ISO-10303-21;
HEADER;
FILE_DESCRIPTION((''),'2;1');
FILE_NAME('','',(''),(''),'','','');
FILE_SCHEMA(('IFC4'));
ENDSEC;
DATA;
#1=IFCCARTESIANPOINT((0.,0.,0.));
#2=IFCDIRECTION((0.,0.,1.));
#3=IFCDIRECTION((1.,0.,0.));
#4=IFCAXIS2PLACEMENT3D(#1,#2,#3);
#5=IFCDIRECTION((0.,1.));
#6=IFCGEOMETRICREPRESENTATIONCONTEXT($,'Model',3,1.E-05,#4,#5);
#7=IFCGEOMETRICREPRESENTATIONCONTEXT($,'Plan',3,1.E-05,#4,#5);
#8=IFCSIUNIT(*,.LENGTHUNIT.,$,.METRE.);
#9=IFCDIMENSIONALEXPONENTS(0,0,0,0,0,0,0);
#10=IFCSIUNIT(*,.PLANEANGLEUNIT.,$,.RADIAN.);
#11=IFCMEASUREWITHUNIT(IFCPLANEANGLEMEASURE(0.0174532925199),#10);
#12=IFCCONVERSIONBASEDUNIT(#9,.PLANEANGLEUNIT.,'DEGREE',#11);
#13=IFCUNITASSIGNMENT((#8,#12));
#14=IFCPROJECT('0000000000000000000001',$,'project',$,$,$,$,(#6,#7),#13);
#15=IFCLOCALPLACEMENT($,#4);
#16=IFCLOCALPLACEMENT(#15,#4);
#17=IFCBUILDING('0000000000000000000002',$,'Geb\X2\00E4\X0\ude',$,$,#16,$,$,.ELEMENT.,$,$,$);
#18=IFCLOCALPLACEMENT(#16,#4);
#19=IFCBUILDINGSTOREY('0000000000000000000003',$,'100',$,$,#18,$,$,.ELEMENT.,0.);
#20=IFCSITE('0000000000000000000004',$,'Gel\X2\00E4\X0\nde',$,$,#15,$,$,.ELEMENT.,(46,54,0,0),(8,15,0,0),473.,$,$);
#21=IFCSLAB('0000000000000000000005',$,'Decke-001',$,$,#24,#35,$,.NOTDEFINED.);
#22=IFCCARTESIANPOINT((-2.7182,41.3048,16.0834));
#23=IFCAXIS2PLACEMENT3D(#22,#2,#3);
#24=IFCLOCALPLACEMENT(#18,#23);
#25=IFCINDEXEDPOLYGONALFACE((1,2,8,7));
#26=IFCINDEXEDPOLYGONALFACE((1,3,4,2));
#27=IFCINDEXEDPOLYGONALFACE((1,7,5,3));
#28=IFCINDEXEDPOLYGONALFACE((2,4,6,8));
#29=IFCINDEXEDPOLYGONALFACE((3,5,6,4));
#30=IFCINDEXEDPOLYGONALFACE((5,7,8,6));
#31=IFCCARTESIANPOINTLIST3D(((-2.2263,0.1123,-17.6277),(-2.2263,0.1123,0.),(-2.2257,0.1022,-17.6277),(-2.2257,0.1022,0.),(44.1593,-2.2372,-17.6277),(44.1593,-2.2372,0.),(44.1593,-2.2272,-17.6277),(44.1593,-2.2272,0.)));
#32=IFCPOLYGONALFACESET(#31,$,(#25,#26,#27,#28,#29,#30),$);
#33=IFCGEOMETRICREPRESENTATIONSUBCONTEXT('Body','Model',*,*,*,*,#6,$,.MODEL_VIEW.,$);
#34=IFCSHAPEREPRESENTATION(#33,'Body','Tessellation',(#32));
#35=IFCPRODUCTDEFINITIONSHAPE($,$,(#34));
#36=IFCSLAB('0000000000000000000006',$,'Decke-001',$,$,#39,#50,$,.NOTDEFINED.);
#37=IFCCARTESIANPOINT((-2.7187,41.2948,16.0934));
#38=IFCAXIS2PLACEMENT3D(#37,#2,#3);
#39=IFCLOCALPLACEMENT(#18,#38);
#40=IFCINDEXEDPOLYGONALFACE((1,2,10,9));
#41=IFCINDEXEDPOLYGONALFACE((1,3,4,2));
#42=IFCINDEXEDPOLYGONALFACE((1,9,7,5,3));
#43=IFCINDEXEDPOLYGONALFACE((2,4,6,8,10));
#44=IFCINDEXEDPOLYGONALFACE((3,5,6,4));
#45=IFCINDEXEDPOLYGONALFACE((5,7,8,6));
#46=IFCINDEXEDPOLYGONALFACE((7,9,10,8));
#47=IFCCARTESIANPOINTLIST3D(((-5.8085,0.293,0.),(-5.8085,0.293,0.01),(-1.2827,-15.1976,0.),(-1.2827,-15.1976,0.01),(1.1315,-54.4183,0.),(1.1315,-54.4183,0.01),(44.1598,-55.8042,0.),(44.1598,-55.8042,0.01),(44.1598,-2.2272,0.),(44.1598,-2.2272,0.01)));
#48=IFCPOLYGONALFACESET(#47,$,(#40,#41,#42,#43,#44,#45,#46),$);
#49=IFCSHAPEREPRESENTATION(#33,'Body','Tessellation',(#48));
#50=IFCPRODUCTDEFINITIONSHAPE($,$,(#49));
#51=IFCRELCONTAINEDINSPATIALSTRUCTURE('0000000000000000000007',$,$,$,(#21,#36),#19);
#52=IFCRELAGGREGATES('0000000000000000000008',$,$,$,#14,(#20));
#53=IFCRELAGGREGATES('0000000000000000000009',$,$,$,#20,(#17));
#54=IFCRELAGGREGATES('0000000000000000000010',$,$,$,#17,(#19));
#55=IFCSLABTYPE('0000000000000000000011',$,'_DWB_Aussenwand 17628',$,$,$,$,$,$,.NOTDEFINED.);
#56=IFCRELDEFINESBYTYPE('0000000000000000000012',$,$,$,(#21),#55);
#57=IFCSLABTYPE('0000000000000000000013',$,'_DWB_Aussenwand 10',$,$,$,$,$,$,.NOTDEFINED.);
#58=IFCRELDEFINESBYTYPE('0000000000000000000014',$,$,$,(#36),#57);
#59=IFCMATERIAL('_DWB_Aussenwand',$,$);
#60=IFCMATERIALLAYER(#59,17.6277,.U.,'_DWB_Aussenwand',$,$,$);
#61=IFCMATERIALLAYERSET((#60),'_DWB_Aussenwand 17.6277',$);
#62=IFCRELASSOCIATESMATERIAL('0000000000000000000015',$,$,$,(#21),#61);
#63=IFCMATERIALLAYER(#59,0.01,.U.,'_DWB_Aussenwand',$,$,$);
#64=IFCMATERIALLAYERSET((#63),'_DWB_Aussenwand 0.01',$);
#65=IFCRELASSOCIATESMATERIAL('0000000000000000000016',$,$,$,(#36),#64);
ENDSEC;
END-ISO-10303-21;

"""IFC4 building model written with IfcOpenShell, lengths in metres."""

from ifc_helpers import new_model, entity, si_unit, converted_unit, direction, frame, origin_with_axes, place, context, subcontext, project, spatial, line, indexed_curve, outline, extrude, material, layer, layer_set, layer_usage, type_object, element, save


model = new_model("IFC4")

# Units and contexts
model_context = context("Model", 3, precision=1e-05, world=origin_with_axes(), true_north=direction((0.0, 1.0)))
plan_context = context("Plan", 3, precision=1e-05, world=origin_with_axes(), true_north=direction((0.0, 1.0)))
body_context = subcontext(model_context, "Body", "Model", "MODEL_VIEW")
ifc_project = project(units=[si_unit("LENGTHUNIT", "METRE"), converted_unit("PLANEANGLEUNIT", "DEGREE", entity("IfcPlaneAngleMeasure", 0.0174532925199), si_unit("PLANEANGLEUNIT", "RADIAN"), dimensions=[0, 0, 0, 0, 0, 0, 0])], contexts=[model_context, plan_context])

# Site, building, storey
site_placement = place(None, origin_with_axes())
site = spatial("IfcSite", under=ifc_project, at=site_placement, Name="Gelände", CompositionType="ELEMENT", RefLatitude=(46, 54, 0, 0), RefLongitude=(8, 15, 0, 0), RefElevation=473.0)
building_placement = place(site_placement, origin_with_axes())
building = spatial("IfcBuilding", under=site, at=building_placement, Name="Gebäude", CompositionType="ELEMENT")
storey_placement = place(building_placement, origin_with_axes())
storey = spatial("IfcBuildingStorey", under=building, at=storey_placement, Name="100", CompositionType="ELEMENT", Elevation=0.0)

# Slabs
ifc_material = material(Name="_DWB_Aussenwand")
ifc_layer_1 = layer(ifc_material, 17.6277, ventilated="UNKNOWN", Name="_DWB_Aussenwand")
ifc_layer_set_1 = layer_set([ifc_layer_1], Name="_DWB_Aussenwand 17.6277")
slab_type_1 = type_object("IfcSlabType", Name="_DWB_Aussenwand 17628", PredefinedType="NOTDEFINED")
ifc_layer_usage_1 = layer_usage(ifc_layer_set_1, "AXIS3", "NEGATIVE", 17.6277)
slab_1_placement = place(storey_placement, frame((-2.7182, 41.3048, 16.0834), z_axis=(0.0, 0.0, 1.0), x_axis=(1.0, 0.0, 0.0)))
element("IfcSlab", 1, at=slab_1_placement, inside=storey, type_object=slab_type_1, material=ifc_layer_usage_1, Name="Decke-001", PredefinedType="NOTDEFINED", context=body_context, shape_type="SweptSolid", body=[
    extrude(outline(indexed_curve([(-2.2263, 0.1123), (-2.2257, 0.1022), (44.1593, -2.2372), (44.1593, -2.2272)], segments=[line(1, 2, 3, 4, 1)])), frame((0.0, 0.0, -17.6277), z_axis=(0.0, 0.0, 1.0), x_axis=(1.0, 0.0, 0.0)), (0.0, 0.0, 1.0), 17.6277),
])
ifc_layer_2 = layer(ifc_material, 0.01, ventilated="UNKNOWN", Name="_DWB_Aussenwand")
ifc_layer_set_2 = layer_set([ifc_layer_2], Name="_DWB_Aussenwand 0.01")
ifc_layer_usage_2 = layer_usage(ifc_layer_set_2, "AXIS3", "NEGATIVE", 0.01)
slab_type_2 = type_object("IfcSlabType", Name="_DWB_Aussenwand 10", PredefinedType="NOTDEFINED")
slab_2_placement = place(storey_placement, frame((-2.7187, 41.2948, 16.0934), z_axis=(0.0, 0.0, 1.0), x_axis=(1.0, 0.0, 0.0)))
element("IfcSlab", 2, at=slab_2_placement, inside=storey, type_object=slab_type_2, material=ifc_layer_usage_2, Name="Decke-001", PredefinedType="NOTDEFINED", context=body_context, shape_type="SweptSolid", body=[
    extrude(outline(indexed_curve([(-5.8085, 0.293), (-1.2827, -15.1976), (1.1315, -54.4183), (44.1598, -55.8042), (44.1598, -2.2272)], segments=[line(1, 2, 3, 4, 5, 1)])), origin_with_axes(), (0.0, 0.0, 1.0), 0.01),
])

save(model, "model.ifc")
